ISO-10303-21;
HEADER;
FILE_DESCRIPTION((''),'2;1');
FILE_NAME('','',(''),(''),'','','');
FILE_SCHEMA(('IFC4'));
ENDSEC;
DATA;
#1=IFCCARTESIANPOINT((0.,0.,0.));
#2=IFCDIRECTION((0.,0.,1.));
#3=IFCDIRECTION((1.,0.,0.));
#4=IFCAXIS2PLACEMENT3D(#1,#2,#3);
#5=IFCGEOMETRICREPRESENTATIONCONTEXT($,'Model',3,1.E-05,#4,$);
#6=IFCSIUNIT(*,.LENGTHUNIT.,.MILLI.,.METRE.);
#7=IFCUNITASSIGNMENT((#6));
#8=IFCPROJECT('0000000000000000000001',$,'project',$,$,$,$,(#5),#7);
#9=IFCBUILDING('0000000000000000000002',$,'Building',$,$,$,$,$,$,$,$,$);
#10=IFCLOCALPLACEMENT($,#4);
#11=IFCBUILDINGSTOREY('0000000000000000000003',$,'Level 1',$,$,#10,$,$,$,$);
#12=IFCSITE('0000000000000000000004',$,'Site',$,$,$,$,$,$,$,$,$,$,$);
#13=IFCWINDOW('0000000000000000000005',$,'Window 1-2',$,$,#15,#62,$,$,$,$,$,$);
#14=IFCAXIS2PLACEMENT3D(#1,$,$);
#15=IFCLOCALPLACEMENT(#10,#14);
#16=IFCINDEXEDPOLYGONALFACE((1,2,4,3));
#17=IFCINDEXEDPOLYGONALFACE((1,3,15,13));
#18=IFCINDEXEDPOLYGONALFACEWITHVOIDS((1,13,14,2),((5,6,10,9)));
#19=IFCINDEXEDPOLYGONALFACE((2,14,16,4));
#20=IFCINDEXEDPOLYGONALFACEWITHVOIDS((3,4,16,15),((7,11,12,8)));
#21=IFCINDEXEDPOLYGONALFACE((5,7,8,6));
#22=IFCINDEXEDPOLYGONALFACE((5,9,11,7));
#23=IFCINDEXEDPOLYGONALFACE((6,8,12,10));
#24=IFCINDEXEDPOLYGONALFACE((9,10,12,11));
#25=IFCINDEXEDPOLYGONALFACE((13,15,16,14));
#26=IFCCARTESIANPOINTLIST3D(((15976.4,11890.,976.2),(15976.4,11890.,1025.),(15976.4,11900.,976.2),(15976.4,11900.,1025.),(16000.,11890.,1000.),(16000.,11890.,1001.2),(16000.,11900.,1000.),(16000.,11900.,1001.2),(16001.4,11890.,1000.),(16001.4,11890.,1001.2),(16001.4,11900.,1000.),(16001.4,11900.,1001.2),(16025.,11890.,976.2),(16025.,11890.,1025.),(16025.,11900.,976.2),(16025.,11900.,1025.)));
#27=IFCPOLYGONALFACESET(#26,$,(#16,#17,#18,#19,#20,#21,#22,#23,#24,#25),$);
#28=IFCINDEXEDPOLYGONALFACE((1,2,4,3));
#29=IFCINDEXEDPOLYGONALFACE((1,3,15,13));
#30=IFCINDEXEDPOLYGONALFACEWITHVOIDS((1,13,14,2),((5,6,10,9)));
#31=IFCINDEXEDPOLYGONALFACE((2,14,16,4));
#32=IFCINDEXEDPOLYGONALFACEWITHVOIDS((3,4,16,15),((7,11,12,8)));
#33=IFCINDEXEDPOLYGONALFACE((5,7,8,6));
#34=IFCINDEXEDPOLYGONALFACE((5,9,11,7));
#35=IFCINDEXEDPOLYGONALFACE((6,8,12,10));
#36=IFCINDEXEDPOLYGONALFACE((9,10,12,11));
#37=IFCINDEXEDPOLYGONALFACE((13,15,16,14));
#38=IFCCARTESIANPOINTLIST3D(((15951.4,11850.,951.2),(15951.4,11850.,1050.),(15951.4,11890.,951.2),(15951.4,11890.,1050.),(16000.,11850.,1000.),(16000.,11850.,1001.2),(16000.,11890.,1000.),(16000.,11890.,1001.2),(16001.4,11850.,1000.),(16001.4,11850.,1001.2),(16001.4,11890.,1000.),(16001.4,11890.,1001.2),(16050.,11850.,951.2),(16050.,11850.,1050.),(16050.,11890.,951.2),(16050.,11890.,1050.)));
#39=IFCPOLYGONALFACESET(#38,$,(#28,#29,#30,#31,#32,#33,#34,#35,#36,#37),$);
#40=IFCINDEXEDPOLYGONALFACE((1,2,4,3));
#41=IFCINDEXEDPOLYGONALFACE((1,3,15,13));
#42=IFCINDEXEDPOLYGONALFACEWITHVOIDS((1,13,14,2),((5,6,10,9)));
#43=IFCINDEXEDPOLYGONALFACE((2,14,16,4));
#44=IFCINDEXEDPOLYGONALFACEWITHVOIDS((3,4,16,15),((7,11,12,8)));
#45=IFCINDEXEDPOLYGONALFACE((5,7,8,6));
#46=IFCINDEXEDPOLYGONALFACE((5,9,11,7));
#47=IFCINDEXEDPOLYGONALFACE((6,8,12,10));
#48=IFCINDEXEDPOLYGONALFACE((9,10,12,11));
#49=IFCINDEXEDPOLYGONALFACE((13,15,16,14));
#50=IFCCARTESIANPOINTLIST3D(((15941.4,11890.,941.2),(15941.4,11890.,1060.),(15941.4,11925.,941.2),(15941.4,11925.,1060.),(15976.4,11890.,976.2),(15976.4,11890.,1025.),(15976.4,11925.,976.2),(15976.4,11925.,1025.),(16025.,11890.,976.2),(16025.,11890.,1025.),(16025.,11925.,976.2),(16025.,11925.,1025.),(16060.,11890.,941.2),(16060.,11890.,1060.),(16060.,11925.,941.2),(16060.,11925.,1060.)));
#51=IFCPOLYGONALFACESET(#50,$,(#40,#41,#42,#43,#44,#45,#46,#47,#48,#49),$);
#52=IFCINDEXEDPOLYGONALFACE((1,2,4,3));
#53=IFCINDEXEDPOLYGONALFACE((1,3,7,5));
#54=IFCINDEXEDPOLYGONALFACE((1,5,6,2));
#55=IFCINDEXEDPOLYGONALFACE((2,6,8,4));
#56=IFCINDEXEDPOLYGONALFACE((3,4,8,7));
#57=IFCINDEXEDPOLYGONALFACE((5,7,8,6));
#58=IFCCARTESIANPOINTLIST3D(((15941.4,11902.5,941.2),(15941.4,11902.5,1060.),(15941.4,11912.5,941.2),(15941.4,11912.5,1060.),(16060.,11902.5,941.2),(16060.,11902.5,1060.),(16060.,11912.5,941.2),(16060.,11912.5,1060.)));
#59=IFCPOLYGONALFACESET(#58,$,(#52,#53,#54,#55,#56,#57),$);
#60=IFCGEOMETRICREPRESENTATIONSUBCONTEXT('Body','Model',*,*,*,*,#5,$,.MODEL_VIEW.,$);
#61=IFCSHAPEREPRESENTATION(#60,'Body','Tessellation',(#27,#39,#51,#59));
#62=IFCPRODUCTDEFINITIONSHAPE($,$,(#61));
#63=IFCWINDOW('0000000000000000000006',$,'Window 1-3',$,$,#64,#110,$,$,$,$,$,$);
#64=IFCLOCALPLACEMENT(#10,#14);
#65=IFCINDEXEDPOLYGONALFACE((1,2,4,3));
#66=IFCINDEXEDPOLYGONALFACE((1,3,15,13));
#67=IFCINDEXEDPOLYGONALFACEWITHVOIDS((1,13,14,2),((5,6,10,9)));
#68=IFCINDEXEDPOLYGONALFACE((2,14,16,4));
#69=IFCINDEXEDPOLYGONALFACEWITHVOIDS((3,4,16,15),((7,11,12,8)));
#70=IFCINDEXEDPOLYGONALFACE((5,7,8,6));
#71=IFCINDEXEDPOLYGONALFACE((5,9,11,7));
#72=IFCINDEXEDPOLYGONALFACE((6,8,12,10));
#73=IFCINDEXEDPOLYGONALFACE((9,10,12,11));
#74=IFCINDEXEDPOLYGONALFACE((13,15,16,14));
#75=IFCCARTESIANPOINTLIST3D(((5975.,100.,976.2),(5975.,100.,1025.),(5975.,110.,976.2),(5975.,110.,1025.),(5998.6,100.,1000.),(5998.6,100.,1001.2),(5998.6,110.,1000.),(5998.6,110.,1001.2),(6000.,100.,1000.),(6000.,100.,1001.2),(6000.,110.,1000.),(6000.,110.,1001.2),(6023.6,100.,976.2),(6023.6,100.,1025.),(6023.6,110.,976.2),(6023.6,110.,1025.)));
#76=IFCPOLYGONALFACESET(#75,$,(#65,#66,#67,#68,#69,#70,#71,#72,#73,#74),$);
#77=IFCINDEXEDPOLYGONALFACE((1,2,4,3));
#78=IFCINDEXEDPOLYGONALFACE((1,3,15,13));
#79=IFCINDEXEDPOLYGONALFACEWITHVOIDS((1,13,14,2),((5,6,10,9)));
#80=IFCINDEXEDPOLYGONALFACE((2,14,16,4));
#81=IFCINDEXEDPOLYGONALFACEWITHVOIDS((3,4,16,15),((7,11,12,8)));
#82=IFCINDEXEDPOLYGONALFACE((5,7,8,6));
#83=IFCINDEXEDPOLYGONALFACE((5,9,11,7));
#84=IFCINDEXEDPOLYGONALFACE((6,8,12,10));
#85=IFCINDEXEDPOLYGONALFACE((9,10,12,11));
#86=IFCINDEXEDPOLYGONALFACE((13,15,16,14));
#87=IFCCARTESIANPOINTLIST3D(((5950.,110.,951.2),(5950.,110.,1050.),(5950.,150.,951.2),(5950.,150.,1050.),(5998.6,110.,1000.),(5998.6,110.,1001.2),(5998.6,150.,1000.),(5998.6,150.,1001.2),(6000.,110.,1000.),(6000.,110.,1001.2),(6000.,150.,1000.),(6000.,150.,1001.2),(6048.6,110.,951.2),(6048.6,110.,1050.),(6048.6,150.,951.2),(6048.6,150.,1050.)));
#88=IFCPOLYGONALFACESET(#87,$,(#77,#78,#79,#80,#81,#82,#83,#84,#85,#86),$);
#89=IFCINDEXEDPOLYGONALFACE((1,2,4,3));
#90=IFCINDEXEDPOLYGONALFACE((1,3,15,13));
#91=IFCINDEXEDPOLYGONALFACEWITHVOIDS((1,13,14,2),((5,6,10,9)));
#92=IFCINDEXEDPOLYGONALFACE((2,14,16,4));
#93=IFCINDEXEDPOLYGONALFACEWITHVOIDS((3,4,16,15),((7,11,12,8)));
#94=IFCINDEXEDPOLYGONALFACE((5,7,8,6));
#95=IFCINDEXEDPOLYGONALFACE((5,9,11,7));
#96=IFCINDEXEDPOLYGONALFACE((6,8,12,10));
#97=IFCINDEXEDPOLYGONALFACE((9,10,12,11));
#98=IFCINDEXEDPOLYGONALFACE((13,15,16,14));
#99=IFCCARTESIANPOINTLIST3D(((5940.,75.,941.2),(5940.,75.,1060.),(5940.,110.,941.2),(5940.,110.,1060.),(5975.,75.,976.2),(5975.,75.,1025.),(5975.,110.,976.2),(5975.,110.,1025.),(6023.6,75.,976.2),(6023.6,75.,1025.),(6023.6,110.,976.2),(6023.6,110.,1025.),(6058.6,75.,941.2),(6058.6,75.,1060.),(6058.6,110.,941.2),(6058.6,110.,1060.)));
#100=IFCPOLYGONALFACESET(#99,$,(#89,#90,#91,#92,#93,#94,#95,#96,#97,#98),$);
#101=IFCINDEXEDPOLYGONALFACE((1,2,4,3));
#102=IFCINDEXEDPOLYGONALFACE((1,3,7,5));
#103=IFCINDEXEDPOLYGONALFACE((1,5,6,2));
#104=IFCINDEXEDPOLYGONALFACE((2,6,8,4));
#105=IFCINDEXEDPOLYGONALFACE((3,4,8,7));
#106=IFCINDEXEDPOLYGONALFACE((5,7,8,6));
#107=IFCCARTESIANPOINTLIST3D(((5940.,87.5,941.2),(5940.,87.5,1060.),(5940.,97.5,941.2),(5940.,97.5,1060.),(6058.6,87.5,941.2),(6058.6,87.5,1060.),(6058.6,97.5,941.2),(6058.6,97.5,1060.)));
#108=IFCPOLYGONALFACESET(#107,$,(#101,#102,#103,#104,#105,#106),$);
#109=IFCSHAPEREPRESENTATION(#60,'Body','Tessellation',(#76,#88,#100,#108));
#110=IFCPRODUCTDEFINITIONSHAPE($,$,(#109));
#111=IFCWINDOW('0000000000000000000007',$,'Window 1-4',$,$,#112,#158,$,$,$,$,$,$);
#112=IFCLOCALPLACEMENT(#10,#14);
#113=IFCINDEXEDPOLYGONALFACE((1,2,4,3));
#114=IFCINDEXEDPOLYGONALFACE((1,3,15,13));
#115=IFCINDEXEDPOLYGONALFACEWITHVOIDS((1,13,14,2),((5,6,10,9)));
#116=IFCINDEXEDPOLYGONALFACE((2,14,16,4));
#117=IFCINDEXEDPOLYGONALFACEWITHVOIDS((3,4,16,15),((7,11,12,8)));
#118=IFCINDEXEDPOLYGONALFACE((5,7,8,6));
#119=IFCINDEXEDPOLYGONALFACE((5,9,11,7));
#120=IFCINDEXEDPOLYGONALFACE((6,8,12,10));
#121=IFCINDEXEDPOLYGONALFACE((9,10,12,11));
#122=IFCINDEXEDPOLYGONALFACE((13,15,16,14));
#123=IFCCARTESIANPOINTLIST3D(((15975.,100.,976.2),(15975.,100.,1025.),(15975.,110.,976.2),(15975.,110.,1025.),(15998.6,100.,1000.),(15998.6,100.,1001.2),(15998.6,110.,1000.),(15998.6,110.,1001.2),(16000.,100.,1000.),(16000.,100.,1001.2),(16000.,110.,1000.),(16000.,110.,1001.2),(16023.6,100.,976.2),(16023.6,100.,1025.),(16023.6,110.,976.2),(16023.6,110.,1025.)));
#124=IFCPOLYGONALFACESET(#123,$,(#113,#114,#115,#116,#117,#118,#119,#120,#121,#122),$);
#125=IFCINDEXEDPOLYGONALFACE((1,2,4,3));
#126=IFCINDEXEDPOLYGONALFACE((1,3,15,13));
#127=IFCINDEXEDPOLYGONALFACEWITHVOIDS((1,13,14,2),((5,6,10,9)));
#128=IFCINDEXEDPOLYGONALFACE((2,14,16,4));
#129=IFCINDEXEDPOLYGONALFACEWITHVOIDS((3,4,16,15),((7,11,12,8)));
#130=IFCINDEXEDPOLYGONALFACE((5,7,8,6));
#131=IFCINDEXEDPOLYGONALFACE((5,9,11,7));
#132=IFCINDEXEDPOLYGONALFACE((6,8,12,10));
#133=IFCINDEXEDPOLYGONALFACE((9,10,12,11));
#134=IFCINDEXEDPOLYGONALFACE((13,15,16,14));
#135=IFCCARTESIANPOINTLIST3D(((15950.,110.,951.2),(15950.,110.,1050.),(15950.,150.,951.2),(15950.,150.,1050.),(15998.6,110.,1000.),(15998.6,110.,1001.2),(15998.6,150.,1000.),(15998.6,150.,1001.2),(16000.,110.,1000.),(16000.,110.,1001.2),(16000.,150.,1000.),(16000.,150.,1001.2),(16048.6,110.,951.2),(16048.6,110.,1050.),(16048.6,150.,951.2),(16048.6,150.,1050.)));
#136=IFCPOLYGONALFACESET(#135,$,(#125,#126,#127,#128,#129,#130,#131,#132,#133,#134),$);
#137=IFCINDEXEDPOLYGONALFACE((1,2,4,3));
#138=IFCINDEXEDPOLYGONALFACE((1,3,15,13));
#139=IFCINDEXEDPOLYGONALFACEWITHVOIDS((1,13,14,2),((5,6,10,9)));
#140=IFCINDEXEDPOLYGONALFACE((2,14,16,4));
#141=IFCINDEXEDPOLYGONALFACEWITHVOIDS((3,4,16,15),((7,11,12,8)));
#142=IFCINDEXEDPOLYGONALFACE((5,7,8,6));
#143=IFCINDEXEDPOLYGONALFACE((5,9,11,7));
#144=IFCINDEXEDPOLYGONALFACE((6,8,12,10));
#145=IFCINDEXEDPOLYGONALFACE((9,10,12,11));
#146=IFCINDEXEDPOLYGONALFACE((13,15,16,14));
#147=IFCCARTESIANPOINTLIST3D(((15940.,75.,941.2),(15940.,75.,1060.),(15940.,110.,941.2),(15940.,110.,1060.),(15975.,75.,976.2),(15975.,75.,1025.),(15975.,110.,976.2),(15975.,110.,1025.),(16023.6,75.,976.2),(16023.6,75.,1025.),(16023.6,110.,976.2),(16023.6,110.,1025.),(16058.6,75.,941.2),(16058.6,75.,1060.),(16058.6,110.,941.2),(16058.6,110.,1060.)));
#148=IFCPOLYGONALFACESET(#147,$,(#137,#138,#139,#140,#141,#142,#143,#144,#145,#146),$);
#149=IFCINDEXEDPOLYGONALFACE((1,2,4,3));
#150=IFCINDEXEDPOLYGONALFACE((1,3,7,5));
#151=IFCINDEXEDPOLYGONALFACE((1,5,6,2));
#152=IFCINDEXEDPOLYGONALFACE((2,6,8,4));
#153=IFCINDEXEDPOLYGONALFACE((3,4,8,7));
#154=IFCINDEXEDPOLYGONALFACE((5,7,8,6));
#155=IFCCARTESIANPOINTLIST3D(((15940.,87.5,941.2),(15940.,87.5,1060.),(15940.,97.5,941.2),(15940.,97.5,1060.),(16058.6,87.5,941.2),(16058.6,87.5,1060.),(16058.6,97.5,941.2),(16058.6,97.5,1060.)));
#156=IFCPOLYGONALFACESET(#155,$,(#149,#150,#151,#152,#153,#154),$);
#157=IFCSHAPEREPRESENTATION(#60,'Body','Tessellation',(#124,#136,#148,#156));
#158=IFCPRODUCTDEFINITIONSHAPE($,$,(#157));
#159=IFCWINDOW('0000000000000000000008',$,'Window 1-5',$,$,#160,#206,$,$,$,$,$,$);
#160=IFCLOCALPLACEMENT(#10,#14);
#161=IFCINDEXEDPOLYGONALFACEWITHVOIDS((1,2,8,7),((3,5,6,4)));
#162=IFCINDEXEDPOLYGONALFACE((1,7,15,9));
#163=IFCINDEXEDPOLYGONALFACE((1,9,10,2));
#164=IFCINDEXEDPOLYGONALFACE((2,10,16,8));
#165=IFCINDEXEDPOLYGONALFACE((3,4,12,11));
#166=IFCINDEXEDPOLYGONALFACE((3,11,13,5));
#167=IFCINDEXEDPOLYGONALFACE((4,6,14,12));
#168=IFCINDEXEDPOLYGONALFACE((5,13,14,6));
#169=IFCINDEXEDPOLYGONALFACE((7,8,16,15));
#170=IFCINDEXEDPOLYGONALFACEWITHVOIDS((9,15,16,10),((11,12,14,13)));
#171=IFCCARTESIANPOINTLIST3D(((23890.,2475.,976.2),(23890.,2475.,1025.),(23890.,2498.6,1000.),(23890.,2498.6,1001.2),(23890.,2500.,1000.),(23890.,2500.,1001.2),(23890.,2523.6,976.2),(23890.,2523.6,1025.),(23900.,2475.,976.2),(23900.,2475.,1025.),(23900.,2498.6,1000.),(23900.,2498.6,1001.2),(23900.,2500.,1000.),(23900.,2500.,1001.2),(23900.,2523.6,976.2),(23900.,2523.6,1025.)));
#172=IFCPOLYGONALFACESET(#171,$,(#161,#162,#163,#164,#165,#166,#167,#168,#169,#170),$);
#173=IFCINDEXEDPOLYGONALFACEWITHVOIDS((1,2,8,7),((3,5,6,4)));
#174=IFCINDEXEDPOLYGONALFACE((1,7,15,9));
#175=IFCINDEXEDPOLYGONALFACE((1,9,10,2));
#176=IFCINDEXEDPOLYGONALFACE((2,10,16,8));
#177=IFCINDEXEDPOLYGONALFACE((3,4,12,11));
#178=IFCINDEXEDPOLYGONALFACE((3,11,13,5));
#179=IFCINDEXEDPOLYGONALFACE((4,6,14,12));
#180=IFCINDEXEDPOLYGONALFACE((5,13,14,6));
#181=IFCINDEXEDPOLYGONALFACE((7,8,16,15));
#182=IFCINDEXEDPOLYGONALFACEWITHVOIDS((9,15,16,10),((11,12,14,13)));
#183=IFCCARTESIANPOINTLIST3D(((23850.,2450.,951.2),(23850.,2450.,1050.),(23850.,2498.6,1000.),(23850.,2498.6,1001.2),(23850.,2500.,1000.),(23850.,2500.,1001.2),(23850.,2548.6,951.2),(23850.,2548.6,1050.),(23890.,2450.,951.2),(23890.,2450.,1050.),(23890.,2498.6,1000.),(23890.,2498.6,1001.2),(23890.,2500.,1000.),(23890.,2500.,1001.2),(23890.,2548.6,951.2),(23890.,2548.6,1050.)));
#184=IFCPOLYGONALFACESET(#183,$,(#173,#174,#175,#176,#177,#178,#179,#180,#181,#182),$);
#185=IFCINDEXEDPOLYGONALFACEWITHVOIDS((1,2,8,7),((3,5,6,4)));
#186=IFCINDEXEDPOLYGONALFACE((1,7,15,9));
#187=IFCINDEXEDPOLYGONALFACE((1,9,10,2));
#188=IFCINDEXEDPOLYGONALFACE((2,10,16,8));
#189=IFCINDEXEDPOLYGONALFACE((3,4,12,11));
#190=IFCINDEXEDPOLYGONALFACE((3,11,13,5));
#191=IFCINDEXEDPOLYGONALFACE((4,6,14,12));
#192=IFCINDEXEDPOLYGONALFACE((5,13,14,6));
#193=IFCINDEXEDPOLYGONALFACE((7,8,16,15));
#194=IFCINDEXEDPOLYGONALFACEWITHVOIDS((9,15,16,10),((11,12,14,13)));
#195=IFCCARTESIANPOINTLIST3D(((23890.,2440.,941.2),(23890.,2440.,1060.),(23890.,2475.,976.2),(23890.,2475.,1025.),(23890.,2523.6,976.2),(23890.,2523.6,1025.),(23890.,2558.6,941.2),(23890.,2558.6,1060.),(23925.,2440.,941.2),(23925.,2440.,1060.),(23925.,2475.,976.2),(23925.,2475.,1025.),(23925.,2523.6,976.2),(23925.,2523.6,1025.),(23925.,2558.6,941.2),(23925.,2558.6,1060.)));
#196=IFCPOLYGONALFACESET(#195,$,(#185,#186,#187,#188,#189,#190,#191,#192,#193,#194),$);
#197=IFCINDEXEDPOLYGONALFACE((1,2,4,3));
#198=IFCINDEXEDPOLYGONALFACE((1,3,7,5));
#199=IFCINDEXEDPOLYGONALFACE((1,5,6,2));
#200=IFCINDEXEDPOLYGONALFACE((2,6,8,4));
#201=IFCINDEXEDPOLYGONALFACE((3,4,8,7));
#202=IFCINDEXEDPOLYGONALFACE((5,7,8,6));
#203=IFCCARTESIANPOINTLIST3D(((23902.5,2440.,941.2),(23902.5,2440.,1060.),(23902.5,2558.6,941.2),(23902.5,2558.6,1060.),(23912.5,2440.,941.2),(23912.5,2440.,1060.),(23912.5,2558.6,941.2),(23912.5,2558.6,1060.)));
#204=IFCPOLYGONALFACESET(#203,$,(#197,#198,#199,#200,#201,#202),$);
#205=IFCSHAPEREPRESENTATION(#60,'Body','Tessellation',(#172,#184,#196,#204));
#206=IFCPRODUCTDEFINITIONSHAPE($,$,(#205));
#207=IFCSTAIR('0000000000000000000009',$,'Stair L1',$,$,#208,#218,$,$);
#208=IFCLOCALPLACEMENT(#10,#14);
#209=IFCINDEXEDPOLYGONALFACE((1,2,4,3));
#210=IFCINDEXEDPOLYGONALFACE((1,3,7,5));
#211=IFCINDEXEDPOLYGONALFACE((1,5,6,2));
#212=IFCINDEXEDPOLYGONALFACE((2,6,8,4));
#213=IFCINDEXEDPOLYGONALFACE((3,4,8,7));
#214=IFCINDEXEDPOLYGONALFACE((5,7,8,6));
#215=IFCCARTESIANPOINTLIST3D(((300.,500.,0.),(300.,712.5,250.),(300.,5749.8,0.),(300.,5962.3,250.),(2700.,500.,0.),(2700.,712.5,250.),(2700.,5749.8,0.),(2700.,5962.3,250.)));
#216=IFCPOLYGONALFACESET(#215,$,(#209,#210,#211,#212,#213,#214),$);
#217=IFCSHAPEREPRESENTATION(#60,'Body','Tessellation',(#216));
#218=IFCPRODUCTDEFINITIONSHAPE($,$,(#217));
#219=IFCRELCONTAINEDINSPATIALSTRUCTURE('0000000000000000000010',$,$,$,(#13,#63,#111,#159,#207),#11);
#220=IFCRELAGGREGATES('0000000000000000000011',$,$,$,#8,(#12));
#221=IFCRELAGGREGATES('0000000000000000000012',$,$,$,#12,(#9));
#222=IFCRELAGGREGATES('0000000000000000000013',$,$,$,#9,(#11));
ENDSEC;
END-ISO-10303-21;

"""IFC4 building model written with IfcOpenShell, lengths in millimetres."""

from ifc_helpers import new_model, si_unit, frame, origin_with_axes, place, context, subcontext, project, spatial, line, indexed_curve, outline, extrude, element, save


model = new_model("IFC4")

# Units and contexts
model_context = context("Model", 3, precision=1e-05, world=origin_with_axes())
body_context = subcontext(model_context, "Body", "Model", "MODEL_VIEW")
ifc_project = project(units=[si_unit("LENGTHUNIT", "METRE", prefix="MILLI")], contexts=[model_context])

# Site, building, storey
site = spatial("IfcSite", under=ifc_project, Name="Site")
building = spatial("IfcBuilding", under=site, Name="Building")
storey_placement = place(None, origin_with_axes())
storey = spatial("IfcBuildingStorey", under=building, at=storey_placement, Name="Level 1")

# Windows
for number, where, z_axis, x_axis, name in (
    (1, (16000.0, 11800.0, 1000.0), (0.0, 0.0, 1.0), (1.0, 0.0, 0.0), "Window 1-2"),
    (2, (6000.0, 200.0, 1000.0), (0.0, 0.0, 1.0), (-1.0, 0.0, 0.0), "Window 1-3"),
    (3, (16000.0, 200.0, 1000.0), (0.0, 0.0, 1.0), (-1.0, 0.0, 0.0), "Window 1-4"),
    (4, (23800.0, 2500.0, 1000.0), (0.0, 0.0, 1.0), (0.0, -1.0, 0.0), "Window 1-5"),
):
    element("IfcWindow", number, at=place(storey_placement, frame(where, z_axis=z_axis, x_axis=x_axis)), inside=storey, Name=name, context=body_context, shape_type="SweptSolid", body=[
        extrude(outline(indexed_curve([(0.0, 0.0), (1.4, 0.0), (1.4, 1.2), (0.0, 1.2)], segments=[line(1, 2, 3, 4, 1)]), holes=[indexed_curve([(25.0, 25.0), (-23.6, 25.0), (-23.6, -23.8), (25.0, -23.8)], segments=[line(1, 2, 3, 4, 1)])]), frame((0.0, 90.0, 0.0), z_axis=(0.0, -1.0, 0.0), x_axis=(1.0, 0.0, 0.0)), (0.0, 0.0, -1.0), 10.0),
        extrude(outline(indexed_curve([(0.0, 0.0), (1.4, 0.0), (1.4, 1.2), (0.0, 1.2)], segments=[line(1, 2, 3, 4, 1)]), holes=[indexed_curve([(50.0, 50.0), (-48.6, 50.0), (-48.6, -48.8), (50.0, -48.8)], segments=[line(1, 2, 3, 4, 1)])]), frame((0.0, 50.0, 0.0), z_axis=(0.0, -1.0, 0.0), x_axis=(1.0, 0.0, 0.0)), (0.0, 0.0, -1.0), 40.0),
        extrude(outline(indexed_curve([(0.0, 0.0), (-48.6, 0.0), (-48.6, -48.8), (0.0, -48.8)], segments=[line(1, 2, 3, 4, 1)]), holes=[indexed_curve([(35.0, 35.0), (-83.6, 35.0), (-83.6, -83.8), (35.0, -83.8)], segments=[line(1, 2, 3, 4, 1)])]), frame((25.0, 90.0, 25.0), z_axis=(0.0, -1.0, 0.0), x_axis=(1.0, 0.0, 0.0)), (0.0, 0.0, -1.0), 35.0),
        extrude(outline(indexed_curve([(35.0, 35.0), (-83.6, 35.0), (-83.6, -83.8), (35.0, -83.8)], segments=[line(1, 2, 3, 4, 1)])), frame((25.0, 102.5, 25.0), z_axis=(0.0, -1.0, 0.0), x_axis=(1.0, 0.0, 0.0)), (0.0, 0.0, -1.0), 10.0),
    ])

# Stair
stair_placement = place(storey_placement, frame((300.0, 500.0, 0.0), z_axis=(0.0, 0.0, 1.0), x_axis=(1.0, 0.0, 0.0)))
element("IfcStair", 5, at=stair_placement, inside=storey, Name="Stair L1", context=body_context, shape_type="SweptSolid", body=[
    extrude(outline(indexed_curve([(0.0, 0.0), (2400.0, 0.0), (2400.0, 5249.8), (0.0, 5249.8), (0.0, 0.0)])), None, (0.0, 0.647648, 0.761939), 328.1),
])

save(model, "model.ifc")
